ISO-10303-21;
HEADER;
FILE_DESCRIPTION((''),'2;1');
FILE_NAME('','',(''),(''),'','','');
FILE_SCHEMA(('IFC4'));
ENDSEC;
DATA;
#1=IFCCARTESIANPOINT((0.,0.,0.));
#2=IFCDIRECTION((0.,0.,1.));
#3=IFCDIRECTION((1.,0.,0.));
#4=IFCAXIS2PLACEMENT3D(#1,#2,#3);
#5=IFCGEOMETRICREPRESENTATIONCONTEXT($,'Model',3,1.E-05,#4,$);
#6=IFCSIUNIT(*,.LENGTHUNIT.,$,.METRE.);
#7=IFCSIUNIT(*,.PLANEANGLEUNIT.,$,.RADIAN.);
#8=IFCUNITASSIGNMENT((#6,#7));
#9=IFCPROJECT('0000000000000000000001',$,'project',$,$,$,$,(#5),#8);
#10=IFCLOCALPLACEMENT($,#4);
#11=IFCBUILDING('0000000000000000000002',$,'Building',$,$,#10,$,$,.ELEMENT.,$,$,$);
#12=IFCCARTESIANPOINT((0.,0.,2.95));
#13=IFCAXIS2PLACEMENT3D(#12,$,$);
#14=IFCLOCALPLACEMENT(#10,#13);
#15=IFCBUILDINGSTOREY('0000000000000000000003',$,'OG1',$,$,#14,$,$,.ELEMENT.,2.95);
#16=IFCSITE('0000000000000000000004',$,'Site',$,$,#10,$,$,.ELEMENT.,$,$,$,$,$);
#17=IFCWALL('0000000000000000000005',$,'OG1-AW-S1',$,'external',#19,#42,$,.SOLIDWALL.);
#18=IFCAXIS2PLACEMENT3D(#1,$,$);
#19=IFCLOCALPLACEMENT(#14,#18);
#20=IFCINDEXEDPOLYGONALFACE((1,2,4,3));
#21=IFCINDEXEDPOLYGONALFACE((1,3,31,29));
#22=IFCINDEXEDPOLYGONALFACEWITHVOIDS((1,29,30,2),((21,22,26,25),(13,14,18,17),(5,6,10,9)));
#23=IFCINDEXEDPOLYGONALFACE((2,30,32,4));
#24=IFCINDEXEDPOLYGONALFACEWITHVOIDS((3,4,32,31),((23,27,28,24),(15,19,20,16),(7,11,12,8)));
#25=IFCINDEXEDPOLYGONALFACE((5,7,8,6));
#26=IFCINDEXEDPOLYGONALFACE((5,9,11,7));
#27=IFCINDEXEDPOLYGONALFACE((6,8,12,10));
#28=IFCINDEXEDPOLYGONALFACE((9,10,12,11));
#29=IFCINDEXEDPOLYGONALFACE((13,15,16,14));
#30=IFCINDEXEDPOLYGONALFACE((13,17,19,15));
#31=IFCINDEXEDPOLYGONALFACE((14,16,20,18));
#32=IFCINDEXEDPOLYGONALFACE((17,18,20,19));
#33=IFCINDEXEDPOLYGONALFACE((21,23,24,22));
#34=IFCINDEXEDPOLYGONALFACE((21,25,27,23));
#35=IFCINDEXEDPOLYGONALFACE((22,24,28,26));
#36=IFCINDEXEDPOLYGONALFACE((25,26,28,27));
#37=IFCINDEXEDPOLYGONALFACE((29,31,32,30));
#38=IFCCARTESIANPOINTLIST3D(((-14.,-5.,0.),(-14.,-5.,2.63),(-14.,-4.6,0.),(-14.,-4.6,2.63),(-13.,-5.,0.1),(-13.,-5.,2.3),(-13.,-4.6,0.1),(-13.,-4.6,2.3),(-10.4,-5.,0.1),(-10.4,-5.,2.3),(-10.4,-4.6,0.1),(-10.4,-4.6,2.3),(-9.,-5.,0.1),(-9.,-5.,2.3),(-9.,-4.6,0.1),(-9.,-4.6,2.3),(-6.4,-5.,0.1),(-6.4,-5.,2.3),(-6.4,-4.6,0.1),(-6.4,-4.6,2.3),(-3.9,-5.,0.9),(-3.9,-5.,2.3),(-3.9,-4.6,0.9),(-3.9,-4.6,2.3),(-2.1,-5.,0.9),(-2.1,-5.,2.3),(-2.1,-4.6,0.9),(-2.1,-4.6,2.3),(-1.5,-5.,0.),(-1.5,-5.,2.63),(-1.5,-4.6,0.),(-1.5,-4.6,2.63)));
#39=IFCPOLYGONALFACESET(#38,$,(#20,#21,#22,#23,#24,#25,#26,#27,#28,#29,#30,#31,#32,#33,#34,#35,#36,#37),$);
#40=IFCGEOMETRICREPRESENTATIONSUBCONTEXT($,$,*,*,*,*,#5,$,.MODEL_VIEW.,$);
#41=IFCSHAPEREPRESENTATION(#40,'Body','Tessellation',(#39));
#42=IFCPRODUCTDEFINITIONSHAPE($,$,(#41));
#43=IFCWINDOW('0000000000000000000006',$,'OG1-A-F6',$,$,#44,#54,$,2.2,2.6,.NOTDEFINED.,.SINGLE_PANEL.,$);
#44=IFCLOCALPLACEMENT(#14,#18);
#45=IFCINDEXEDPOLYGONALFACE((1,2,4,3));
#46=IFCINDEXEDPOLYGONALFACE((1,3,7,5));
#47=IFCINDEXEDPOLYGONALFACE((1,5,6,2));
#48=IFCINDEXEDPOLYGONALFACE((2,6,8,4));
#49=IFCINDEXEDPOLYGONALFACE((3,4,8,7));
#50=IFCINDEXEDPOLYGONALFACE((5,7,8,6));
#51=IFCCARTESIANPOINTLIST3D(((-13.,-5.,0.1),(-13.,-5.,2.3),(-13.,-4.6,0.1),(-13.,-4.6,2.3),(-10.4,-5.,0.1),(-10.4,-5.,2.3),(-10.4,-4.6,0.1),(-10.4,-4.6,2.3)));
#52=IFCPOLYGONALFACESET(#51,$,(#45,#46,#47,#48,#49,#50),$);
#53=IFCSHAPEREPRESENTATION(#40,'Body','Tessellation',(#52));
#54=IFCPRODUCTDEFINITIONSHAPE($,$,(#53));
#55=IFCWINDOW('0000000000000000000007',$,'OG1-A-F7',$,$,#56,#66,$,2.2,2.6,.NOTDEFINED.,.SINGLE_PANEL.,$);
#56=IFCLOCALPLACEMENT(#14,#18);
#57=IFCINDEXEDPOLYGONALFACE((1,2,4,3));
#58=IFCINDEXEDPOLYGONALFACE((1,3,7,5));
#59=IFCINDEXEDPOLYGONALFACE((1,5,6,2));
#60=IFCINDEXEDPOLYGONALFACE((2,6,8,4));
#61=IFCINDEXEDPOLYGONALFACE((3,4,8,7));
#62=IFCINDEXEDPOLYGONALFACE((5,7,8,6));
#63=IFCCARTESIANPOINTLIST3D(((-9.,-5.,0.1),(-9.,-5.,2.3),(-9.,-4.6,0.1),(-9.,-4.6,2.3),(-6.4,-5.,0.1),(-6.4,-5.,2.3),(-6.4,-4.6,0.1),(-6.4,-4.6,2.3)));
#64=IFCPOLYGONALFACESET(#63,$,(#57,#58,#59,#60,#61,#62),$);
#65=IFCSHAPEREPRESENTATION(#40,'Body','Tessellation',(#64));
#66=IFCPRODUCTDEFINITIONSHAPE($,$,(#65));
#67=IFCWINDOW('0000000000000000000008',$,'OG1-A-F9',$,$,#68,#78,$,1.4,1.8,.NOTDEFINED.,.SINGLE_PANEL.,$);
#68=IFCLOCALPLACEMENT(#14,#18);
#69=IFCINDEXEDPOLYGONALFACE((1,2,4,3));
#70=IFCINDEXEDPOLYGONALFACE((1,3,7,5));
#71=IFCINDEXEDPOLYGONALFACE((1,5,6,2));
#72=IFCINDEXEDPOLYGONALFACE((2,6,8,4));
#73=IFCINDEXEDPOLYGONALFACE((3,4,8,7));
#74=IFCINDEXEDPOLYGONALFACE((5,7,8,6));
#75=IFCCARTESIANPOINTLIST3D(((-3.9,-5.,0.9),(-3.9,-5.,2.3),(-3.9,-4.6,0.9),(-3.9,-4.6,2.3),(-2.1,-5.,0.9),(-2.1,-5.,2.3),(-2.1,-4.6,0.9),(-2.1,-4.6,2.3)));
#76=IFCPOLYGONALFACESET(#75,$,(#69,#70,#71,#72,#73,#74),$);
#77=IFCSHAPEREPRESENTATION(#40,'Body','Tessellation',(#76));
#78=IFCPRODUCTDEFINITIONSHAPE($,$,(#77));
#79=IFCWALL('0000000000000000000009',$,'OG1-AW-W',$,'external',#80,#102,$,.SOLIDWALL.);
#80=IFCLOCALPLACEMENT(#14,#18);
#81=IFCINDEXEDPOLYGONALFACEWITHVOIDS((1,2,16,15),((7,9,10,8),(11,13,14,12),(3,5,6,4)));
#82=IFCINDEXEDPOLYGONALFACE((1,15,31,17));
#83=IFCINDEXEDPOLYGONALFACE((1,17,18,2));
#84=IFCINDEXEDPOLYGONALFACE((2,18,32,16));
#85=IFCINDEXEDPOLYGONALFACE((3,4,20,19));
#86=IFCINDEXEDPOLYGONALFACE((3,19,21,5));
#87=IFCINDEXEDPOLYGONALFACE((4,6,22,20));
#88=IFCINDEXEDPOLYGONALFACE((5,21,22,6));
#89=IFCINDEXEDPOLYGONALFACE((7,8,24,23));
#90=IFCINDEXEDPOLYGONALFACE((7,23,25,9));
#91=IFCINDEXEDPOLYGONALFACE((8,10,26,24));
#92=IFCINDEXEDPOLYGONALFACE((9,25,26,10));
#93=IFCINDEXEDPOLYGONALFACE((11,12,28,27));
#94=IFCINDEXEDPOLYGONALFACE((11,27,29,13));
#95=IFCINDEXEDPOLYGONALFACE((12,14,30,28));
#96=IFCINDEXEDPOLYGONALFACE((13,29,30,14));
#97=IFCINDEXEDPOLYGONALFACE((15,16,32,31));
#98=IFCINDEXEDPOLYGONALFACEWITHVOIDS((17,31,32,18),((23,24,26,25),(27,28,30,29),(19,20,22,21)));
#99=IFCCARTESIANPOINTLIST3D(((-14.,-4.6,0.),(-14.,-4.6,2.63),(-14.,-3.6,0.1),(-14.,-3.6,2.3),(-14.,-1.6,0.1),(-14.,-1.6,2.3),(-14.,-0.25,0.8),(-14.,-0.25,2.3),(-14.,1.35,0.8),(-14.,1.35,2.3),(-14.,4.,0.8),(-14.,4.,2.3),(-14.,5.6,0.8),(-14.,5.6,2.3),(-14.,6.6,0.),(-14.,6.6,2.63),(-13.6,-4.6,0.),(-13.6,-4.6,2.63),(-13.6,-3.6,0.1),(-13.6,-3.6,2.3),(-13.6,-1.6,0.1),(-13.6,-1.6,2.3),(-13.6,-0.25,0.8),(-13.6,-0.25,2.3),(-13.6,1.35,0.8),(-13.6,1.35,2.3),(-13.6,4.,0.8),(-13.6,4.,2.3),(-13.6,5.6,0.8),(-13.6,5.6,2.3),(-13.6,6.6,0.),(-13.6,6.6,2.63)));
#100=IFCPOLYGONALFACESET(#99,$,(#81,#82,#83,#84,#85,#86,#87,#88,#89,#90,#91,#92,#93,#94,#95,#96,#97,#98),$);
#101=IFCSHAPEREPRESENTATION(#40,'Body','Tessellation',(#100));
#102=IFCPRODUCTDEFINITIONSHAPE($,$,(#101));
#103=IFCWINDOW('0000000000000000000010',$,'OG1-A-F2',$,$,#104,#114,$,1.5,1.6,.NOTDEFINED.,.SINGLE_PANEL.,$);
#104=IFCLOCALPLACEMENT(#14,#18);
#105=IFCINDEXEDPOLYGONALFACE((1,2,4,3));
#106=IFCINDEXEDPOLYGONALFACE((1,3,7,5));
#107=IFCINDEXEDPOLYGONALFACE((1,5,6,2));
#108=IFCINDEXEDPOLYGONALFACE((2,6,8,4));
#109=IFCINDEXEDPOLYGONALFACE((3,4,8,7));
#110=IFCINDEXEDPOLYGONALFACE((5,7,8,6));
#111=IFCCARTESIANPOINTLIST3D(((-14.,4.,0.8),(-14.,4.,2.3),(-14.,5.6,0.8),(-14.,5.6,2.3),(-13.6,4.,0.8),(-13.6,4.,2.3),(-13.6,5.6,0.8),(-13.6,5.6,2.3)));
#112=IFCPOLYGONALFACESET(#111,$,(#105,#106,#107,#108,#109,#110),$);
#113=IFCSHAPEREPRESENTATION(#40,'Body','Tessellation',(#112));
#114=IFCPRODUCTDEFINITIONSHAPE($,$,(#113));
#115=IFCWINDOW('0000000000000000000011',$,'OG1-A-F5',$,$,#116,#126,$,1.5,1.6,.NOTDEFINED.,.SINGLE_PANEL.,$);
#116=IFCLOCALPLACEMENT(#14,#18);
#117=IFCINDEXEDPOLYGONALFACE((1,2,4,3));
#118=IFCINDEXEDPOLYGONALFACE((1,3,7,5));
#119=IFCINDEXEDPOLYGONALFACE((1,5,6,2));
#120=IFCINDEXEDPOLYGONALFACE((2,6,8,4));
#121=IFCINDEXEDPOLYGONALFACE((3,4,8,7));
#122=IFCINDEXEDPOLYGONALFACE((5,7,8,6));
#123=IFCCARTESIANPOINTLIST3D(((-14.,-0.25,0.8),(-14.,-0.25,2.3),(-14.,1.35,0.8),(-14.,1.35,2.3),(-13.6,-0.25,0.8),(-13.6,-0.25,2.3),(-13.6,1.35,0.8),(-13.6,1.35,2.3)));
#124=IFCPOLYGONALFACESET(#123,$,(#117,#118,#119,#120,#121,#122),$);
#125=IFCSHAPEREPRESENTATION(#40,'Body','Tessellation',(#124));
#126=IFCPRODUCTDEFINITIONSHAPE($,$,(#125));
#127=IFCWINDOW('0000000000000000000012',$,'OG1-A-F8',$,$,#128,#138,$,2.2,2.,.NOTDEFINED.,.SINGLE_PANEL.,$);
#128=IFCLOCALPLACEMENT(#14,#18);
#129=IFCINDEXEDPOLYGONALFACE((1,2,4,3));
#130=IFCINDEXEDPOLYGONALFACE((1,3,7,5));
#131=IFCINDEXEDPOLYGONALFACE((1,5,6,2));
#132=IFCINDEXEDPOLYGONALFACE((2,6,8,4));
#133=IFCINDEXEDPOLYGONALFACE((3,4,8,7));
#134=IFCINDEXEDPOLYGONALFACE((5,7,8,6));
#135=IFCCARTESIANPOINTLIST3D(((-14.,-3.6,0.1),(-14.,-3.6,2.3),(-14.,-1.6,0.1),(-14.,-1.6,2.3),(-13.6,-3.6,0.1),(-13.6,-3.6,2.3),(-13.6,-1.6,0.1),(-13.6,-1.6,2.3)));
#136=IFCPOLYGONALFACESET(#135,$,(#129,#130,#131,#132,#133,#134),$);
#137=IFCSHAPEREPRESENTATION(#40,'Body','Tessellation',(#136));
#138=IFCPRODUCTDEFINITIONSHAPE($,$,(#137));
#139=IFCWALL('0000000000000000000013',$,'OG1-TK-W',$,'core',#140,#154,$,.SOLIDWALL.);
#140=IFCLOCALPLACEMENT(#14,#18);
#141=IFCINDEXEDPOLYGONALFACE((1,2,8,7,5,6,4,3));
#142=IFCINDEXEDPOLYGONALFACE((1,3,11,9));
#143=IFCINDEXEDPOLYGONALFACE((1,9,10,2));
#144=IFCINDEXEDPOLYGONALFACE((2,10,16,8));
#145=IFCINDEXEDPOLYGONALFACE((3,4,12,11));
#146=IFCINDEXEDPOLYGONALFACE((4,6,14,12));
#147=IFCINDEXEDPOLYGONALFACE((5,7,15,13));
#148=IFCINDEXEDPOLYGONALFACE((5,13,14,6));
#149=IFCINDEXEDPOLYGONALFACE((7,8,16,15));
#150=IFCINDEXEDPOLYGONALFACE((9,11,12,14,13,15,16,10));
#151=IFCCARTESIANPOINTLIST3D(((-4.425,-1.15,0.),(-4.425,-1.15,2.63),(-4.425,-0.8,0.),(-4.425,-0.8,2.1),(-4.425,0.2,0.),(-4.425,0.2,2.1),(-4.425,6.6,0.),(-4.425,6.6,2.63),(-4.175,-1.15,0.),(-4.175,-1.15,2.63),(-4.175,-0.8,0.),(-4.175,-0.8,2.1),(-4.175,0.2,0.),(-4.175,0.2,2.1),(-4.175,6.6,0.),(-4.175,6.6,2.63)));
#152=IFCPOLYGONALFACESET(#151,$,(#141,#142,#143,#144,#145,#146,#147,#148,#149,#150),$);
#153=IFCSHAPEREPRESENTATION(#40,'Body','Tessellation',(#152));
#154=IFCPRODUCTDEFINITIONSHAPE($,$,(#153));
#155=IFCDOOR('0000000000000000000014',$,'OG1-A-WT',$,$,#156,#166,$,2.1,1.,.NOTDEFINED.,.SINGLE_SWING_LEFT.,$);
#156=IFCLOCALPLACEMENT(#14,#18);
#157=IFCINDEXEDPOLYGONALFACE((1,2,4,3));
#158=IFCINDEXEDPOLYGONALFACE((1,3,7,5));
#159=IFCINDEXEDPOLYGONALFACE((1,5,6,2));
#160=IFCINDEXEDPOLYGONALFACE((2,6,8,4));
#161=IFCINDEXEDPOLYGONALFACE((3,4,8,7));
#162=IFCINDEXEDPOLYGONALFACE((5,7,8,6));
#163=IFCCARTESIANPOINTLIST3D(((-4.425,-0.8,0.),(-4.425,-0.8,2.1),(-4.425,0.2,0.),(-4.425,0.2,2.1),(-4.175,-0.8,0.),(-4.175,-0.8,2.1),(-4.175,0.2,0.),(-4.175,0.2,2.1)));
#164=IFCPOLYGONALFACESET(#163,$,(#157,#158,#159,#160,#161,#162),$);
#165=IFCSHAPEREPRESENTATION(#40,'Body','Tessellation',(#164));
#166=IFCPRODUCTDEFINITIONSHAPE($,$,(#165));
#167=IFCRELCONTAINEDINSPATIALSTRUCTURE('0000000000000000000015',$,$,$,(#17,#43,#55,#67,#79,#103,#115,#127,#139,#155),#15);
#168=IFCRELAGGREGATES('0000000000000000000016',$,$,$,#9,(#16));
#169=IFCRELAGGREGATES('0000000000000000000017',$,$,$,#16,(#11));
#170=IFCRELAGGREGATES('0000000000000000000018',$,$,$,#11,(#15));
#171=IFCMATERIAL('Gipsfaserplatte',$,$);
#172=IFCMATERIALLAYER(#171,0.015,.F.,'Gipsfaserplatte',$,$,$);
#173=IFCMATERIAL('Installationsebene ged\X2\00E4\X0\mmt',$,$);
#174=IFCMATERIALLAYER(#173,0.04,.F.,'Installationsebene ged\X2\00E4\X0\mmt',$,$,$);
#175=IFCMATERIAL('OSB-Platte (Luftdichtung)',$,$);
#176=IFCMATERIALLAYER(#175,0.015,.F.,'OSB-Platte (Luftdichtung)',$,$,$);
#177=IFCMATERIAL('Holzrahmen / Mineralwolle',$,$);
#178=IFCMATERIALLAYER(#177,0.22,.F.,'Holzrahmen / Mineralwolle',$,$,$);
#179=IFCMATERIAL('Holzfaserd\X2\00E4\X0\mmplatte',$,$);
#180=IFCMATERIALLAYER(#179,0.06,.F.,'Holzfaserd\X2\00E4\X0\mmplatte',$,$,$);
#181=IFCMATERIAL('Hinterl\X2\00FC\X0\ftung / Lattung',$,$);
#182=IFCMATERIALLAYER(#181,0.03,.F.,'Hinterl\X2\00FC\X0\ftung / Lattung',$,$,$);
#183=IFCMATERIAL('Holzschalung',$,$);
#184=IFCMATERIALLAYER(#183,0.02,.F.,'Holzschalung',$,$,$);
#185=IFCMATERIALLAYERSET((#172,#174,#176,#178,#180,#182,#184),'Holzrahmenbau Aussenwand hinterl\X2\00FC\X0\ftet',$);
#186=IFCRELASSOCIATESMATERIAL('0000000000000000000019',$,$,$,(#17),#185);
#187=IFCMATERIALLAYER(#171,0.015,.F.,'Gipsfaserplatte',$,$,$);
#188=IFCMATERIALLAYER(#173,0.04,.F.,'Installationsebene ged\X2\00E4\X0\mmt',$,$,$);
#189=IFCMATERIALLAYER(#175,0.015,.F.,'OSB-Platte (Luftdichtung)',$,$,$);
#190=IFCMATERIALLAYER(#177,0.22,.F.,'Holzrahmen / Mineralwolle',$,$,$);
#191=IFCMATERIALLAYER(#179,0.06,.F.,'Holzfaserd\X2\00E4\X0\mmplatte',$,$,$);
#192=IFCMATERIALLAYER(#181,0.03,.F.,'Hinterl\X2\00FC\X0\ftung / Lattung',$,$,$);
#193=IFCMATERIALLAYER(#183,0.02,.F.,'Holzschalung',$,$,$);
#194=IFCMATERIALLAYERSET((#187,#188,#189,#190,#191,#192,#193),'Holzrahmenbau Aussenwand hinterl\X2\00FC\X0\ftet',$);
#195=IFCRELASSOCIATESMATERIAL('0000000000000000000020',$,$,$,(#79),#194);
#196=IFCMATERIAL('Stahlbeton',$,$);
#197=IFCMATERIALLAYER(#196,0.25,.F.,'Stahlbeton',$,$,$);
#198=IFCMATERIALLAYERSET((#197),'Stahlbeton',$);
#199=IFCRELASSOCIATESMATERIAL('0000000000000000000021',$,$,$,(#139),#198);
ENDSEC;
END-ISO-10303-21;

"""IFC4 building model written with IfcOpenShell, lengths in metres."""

from ifc_helpers import new_model, si_unit, frame, frame_2d, origin, origin_with_axes, place, context, subcontext, project, spatial, rectangle, extrude, material, layer, layer_set, element, fill, save


model = new_model("IFC4")

# Units and contexts
model_context = context("Model", 3, precision=1e-05, world=origin_with_axes())
sub_context = subcontext(model_context, None, None, "MODEL_VIEW")
ifc_project = project(units=[si_unit("LENGTHUNIT", "METRE"), si_unit("PLANEANGLEUNIT", "RADIAN")], contexts=[model_context])

# Site, building, storey
placement = place(None, origin_with_axes())
site = spatial("IfcSite", under=ifc_project, at=placement, Name="Site", CompositionType="ELEMENT")
building = spatial("IfcBuilding", under=site, at=placement, Name="Building", CompositionType="ELEMENT")
storey_placement = place(placement, frame((0.0, 0.0, 2.95)))
storey = spatial("IfcBuildingStorey", under=building, at=storey_placement, Name="OG1", CompositionType="ELEMENT", Elevation=2.95)

# Walls, openings, windows
ifc_material_1 = material(Name="Gipsfaserplatte")
ifc_layer_1 = layer(ifc_material_1, 0.015, ventilated=False, Name="Gipsfaserplatte")
ifc_material_2 = material(Name="Installationsebene gedämmt")
ifc_layer_2 = layer(ifc_material_2, 0.04, ventilated=False, Name="Installationsebene gedämmt")
ifc_material_3 = material(Name="OSB-Platte (Luftdichtung)")
ifc_layer_3 = layer(ifc_material_3, 0.015, ventilated=False, Name="OSB-Platte (Luftdichtung)")
ifc_material_4 = material(Name="Holzrahmen / Mineralwolle")
ifc_layer_4 = layer(ifc_material_4, 0.22, ventilated=False, Name="Holzrahmen / Mineralwolle")
ifc_material_5 = material(Name="Holzfaserdämmplatte")
ifc_layer_5 = layer(ifc_material_5, 0.06, ventilated=False, Name="Holzfaserdämmplatte")
ifc_material_6 = material(Name="Hinterlüftung / Lattung")
ifc_layer_6 = layer(ifc_material_6, 0.03, ventilated=False, Name="Hinterlüftung / Lattung")
ifc_material_7 = material(Name="Holzschalung")
ifc_layer_7 = layer(ifc_material_7, 0.02, ventilated=False, Name="Holzschalung")
ifc_layer_set_1 = layer_set([ifc_layer_1, ifc_layer_2, ifc_layer_3, ifc_layer_4, ifc_layer_5, ifc_layer_6, ifc_layer_7], Name="Holzrahmenbau Aussenwand hinterlüftet")
wall_1_placement = place(storey_placement, frame((-14.0, -4.8, 0.0), z_axis=(0.0, 0.0, 1.0), x_axis=(1.0, 0.0, 0.0)))
wall_1 = element("IfcWall", 1, at=wall_1_placement, inside=storey, material=ifc_layer_set_1, Name="OG1-AW-S1", ObjectType="external", PredefinedType="SOLIDWALL", context=sub_context, shape_type="SweptSolid", body=[
    extrude(rectangle(XDim=12.5, YDim=0.4, at=frame_2d((6.25, 0.0))), origin(), (0.0, 0.0, 1.0), 2.63),
])
opening_1_placement = place(wall_1_placement, frame((2.3, 0.25, 0.1), z_axis=(0.0, -1.0, 0.0), x_axis=(1.0, 0.0, 0.0)))
opening_1 = element("IfcOpeningElement", 2, at=opening_1_placement, cuts=wall_1, PredefinedType="OPENING", context=sub_context, shape_type="SweptSolid", body=[
    extrude(rectangle(XDim=2.6, YDim=2.2, at=frame_2d((0.0, 1.1))), origin(), (0.0, 0.0, 1.0), 0.5),
])
opening_2_placement = place(wall_1_placement, frame((6.3, 0.25, 0.1), z_axis=(0.0, -1.0, 0.0), x_axis=(1.0, 0.0, 0.0)))
opening_2 = element("IfcOpeningElement", 3, at=opening_2_placement, cuts=wall_1, PredefinedType="OPENING", context=sub_context, shape_type="SweptSolid", body=[
    extrude(rectangle(XDim=2.6, YDim=2.2, at=frame_2d((0.0, 1.1))), origin(), (0.0, 0.0, 1.0), 0.5),
])
opening_3_placement = place(wall_1_placement, frame((11.0, 0.25, 0.9), z_axis=(0.0, -1.0, 0.0), x_axis=(1.0, 0.0, 0.0)))
opening_3 = element("IfcOpeningElement", 4, at=opening_3_placement, cuts=wall_1, PredefinedType="OPENING", context=sub_context, shape_type="SweptSolid", body=[
    extrude(rectangle(XDim=1.8, YDim=1.4, at=frame_2d((0.0, 0.7))), origin(), (0.0, 0.0, 1.0), 0.5),
])
window_1_placement = place(wall_1_placement, frame((2.3, 0.2, 0.1), z_axis=(0.0, -1.0, 0.0), x_axis=(1.0, 0.0, 0.0)))
window_1 = element("IfcWindow", 5, at=window_1_placement, inside=storey, Name="OG1-A-F6", OverallHeight=2.2, OverallWidth=2.6, PartitioningType="SINGLE_PANEL", PredefinedType="NOTDEFINED", context=sub_context, shape_type="SweptSolid", body=[
    extrude(rectangle(XDim=2.6, YDim=2.2, at=frame_2d((0.0, 1.1))), origin(), (0.0, 0.0, 1.0), 0.4),
])
fill(opening_1, window_1)
window_2_placement = place(wall_1_placement, frame((6.3, 0.2, 0.1), z_axis=(0.0, -1.0, 0.0), x_axis=(1.0, 0.0, 0.0)))
window_2 = element("IfcWindow", 6, at=window_2_placement, inside=storey, Name="OG1-A-F7", OverallHeight=2.2, OverallWidth=2.6, PartitioningType="SINGLE_PANEL", PredefinedType="NOTDEFINED", context=sub_context, shape_type="SweptSolid", body=[
    extrude(rectangle(XDim=2.6, YDim=2.2, at=frame_2d((0.0, 1.1))), origin(), (0.0, 0.0, 1.0), 0.4),
])
fill(opening_2, window_2)
window_3_placement = place(wall_1_placement, frame((11.0, 0.2, 0.9), z_axis=(0.0, -1.0, 0.0), x_axis=(1.0, 0.0, 0.0)))
window_3 = element("IfcWindow", 7, at=window_3_placement, inside=storey, Name="OG1-A-F9", OverallHeight=1.4, OverallWidth=1.8, PartitioningType="SINGLE_PANEL", PredefinedType="NOTDEFINED", context=sub_context, shape_type="SweptSolid", body=[
    extrude(rectangle(XDim=1.8, YDim=1.4, at=frame_2d((0.0, 0.7))), origin(), (0.0, 0.0, 1.0), 0.4),
])
fill(opening_3, window_3)
ifc_layer_8 = layer(ifc_material_1, 0.015, ventilated=False, Name="Gipsfaserplatte")
ifc_layer_9 = layer(ifc_material_2, 0.04, ventilated=False, Name="Installationsebene gedämmt")
ifc_layer_10 = layer(ifc_material_3, 0.015, ventilated=False, Name="OSB-Platte (Luftdichtung)")
ifc_layer_11 = layer(ifc_material_4, 0.22, ventilated=False, Name="Holzrahmen / Mineralwolle")
ifc_layer_12 = layer(ifc_material_5, 0.06, ventilated=False, Name="Holzfaserdämmplatte")
ifc_layer_13 = layer(ifc_material_6, 0.03, ventilated=False, Name="Hinterlüftung / Lattung")
ifc_layer_14 = layer(ifc_material_7, 0.02, ventilated=False, Name="Holzschalung")
ifc_layer_set_2 = layer_set([ifc_layer_8, ifc_layer_9, ifc_layer_10, ifc_layer_11, ifc_layer_12, ifc_layer_13, ifc_layer_14], Name="Holzrahmenbau Aussenwand hinterlüftet")
wall_2_placement = place(storey_placement, frame((-13.8, -4.6, 0.0), z_axis=(0.0, 0.0, 1.0), x_axis=(0.0, 1.0, 0.0)))
wall_2 = element("IfcWall", 8, at=wall_2_placement, inside=storey, material=ifc_layer_set_2, Name="OG1-AW-W", ObjectType="external", PredefinedType="SOLIDWALL", context=sub_context, shape_type="SweptSolid", body=[
    extrude(rectangle(XDim=11.2, YDim=0.4, at=frame_2d((5.6, 0.0))), origin(), (0.0, 0.0, 1.0), 2.63),
])
opening_4_placement = place(wall_2_placement, frame((9.4, 0.25, 0.8), z_axis=(0.0, -1.0, 0.0), x_axis=(1.0, 0.0, 0.0)))
opening_4 = element("IfcOpeningElement", 9, at=opening_4_placement, cuts=wall_2, PredefinedType="OPENING", context=sub_context, shape_type="SweptSolid", body=[
    extrude(rectangle(XDim=1.6, YDim=1.5, at=frame_2d((0.0, 0.75))), origin(), (0.0, 0.0, 1.0), 0.5),
])
opening_5_placement = place(wall_2_placement, frame((5.15, 0.25, 0.8), z_axis=(0.0, -1.0, 0.0), x_axis=(1.0, 0.0, 0.0)))
opening_5 = element("IfcOpeningElement", 10, at=opening_5_placement, cuts=wall_2, PredefinedType="OPENING", context=sub_context, shape_type="SweptSolid", body=[
    extrude(rectangle(XDim=1.6, YDim=1.5, at=frame_2d((0.0, 0.75))), origin(), (0.0, 0.0, 1.0), 0.5),
])
opening_6_placement = place(wall_2_placement, frame((2.0, 0.25, 0.1), z_axis=(0.0, -1.0, 0.0), x_axis=(1.0, 0.0, 0.0)))
opening_6 = element("IfcOpeningElement", 11, at=opening_6_placement, cuts=wall_2, PredefinedType="OPENING", context=sub_context, shape_type="SweptSolid", body=[
    extrude(rectangle(XDim=2.0, YDim=2.2, at=frame_2d((0.0, 1.1))), origin(), (0.0, 0.0, 1.0), 0.5),
])
window_4_placement = place(wall_2_placement, frame((9.4, 0.2, 0.8), z_axis=(0.0, -1.0, 0.0), x_axis=(1.0, 0.0, 0.0)))
window_4 = element("IfcWindow", 12, at=window_4_placement, inside=storey, Name="OG1-A-F2", OverallHeight=1.5, OverallWidth=1.6, PartitioningType="SINGLE_PANEL", PredefinedType="NOTDEFINED", context=sub_context, shape_type="SweptSolid", body=[
    extrude(rectangle(XDim=1.6, YDim=1.5, at=frame_2d((0.0, 0.75))), origin(), (0.0, 0.0, 1.0), 0.4),
])
fill(opening_4, window_4)
window_5_placement = place(wall_2_placement, frame((5.15, 0.2, 0.8), z_axis=(0.0, -1.0, 0.0), x_axis=(1.0, 0.0, 0.0)))
window_5 = element("IfcWindow", 13, at=window_5_placement, inside=storey, Name="OG1-A-F5", OverallHeight=1.5, OverallWidth=1.6, PartitioningType="SINGLE_PANEL", PredefinedType="NOTDEFINED", context=sub_context, shape_type="SweptSolid", body=[
    extrude(rectangle(XDim=1.6, YDim=1.5, at=frame_2d((0.0, 0.75))), origin(), (0.0, 0.0, 1.0), 0.4),
])
fill(opening_5, window_5)
window_6_placement = place(wall_2_placement, frame((2.0, 0.2, 0.1), z_axis=(0.0, -1.0, 0.0), x_axis=(1.0, 0.0, 0.0)))
window_6 = element("IfcWindow", 14, at=window_6_placement, inside=storey, Name="OG1-A-F8", OverallHeight=2.2, OverallWidth=2.0, PartitioningType="SINGLE_PANEL", PredefinedType="NOTDEFINED", context=sub_context, shape_type="SweptSolid", body=[
    extrude(rectangle(XDim=2.0, YDim=2.2, at=frame_2d((0.0, 1.1))), origin(), (0.0, 0.0, 1.0), 0.4),
])
fill(opening_6, window_6)

# Wall, opening, door
ifc_material_8 = material(Name="Stahlbeton")
ifc_layer_15 = layer(ifc_material_8, 0.25, ventilated=False, Name="Stahlbeton")
ifc_layer_set_3 = layer_set([ifc_layer_15], Name="Stahlbeton")
wall_3_placement = place(storey_placement, frame((-4.3, -1.15, 0.0), z_axis=(0.0, 0.0, 1.0), x_axis=(0.0, 1.0, 0.0)))
wall_3 = element("IfcWall", 15, at=wall_3_placement, inside=storey, material=ifc_layer_set_3, Name="OG1-TK-W", ObjectType="core", PredefinedType="SOLIDWALL", context=sub_context, shape_type="SweptSolid", body=[
    extrude(rectangle(XDim=7.75, YDim=0.25, at=frame_2d((3.875, 0.0))), origin(), (0.0, 0.0, 1.0), 2.63),
])
opening_7_placement = place(wall_3_placement, frame((0.85, 0.175, 0.0), z_axis=(0.0, -1.0, 0.0), x_axis=(1.0, 0.0, 0.0)))
opening_7 = element("IfcOpeningElement", 16, at=opening_7_placement, cuts=wall_3, PredefinedType="OPENING", context=sub_context, shape_type="SweptSolid", body=[
    extrude(rectangle(XDim=1.0, YDim=2.1, at=frame_2d((0.0, 1.05))), origin(), (0.0, 0.0, 1.0), 0.35),
])
door_1_placement = place(wall_3_placement, frame((0.85, 0.125, 0.0), z_axis=(0.0, -1.0, 0.0), x_axis=(1.0, 0.0, 0.0)))
door_1 = element("IfcDoor", 17, at=door_1_placement, inside=storey, Name="OG1-A-WT", OperationType="SINGLE_SWING_LEFT", OverallHeight=2.1, OverallWidth=1.0, PredefinedType="NOTDEFINED", context=sub_context, shape_type="SweptSolid", body=[
    extrude(rectangle(XDim=1.0, YDim=2.1, at=frame_2d((0.0, 1.05))), origin(), (0.0, 0.0, 1.0), 0.25),
])
fill(opening_7, door_1)

save(model, "model.ifc")
